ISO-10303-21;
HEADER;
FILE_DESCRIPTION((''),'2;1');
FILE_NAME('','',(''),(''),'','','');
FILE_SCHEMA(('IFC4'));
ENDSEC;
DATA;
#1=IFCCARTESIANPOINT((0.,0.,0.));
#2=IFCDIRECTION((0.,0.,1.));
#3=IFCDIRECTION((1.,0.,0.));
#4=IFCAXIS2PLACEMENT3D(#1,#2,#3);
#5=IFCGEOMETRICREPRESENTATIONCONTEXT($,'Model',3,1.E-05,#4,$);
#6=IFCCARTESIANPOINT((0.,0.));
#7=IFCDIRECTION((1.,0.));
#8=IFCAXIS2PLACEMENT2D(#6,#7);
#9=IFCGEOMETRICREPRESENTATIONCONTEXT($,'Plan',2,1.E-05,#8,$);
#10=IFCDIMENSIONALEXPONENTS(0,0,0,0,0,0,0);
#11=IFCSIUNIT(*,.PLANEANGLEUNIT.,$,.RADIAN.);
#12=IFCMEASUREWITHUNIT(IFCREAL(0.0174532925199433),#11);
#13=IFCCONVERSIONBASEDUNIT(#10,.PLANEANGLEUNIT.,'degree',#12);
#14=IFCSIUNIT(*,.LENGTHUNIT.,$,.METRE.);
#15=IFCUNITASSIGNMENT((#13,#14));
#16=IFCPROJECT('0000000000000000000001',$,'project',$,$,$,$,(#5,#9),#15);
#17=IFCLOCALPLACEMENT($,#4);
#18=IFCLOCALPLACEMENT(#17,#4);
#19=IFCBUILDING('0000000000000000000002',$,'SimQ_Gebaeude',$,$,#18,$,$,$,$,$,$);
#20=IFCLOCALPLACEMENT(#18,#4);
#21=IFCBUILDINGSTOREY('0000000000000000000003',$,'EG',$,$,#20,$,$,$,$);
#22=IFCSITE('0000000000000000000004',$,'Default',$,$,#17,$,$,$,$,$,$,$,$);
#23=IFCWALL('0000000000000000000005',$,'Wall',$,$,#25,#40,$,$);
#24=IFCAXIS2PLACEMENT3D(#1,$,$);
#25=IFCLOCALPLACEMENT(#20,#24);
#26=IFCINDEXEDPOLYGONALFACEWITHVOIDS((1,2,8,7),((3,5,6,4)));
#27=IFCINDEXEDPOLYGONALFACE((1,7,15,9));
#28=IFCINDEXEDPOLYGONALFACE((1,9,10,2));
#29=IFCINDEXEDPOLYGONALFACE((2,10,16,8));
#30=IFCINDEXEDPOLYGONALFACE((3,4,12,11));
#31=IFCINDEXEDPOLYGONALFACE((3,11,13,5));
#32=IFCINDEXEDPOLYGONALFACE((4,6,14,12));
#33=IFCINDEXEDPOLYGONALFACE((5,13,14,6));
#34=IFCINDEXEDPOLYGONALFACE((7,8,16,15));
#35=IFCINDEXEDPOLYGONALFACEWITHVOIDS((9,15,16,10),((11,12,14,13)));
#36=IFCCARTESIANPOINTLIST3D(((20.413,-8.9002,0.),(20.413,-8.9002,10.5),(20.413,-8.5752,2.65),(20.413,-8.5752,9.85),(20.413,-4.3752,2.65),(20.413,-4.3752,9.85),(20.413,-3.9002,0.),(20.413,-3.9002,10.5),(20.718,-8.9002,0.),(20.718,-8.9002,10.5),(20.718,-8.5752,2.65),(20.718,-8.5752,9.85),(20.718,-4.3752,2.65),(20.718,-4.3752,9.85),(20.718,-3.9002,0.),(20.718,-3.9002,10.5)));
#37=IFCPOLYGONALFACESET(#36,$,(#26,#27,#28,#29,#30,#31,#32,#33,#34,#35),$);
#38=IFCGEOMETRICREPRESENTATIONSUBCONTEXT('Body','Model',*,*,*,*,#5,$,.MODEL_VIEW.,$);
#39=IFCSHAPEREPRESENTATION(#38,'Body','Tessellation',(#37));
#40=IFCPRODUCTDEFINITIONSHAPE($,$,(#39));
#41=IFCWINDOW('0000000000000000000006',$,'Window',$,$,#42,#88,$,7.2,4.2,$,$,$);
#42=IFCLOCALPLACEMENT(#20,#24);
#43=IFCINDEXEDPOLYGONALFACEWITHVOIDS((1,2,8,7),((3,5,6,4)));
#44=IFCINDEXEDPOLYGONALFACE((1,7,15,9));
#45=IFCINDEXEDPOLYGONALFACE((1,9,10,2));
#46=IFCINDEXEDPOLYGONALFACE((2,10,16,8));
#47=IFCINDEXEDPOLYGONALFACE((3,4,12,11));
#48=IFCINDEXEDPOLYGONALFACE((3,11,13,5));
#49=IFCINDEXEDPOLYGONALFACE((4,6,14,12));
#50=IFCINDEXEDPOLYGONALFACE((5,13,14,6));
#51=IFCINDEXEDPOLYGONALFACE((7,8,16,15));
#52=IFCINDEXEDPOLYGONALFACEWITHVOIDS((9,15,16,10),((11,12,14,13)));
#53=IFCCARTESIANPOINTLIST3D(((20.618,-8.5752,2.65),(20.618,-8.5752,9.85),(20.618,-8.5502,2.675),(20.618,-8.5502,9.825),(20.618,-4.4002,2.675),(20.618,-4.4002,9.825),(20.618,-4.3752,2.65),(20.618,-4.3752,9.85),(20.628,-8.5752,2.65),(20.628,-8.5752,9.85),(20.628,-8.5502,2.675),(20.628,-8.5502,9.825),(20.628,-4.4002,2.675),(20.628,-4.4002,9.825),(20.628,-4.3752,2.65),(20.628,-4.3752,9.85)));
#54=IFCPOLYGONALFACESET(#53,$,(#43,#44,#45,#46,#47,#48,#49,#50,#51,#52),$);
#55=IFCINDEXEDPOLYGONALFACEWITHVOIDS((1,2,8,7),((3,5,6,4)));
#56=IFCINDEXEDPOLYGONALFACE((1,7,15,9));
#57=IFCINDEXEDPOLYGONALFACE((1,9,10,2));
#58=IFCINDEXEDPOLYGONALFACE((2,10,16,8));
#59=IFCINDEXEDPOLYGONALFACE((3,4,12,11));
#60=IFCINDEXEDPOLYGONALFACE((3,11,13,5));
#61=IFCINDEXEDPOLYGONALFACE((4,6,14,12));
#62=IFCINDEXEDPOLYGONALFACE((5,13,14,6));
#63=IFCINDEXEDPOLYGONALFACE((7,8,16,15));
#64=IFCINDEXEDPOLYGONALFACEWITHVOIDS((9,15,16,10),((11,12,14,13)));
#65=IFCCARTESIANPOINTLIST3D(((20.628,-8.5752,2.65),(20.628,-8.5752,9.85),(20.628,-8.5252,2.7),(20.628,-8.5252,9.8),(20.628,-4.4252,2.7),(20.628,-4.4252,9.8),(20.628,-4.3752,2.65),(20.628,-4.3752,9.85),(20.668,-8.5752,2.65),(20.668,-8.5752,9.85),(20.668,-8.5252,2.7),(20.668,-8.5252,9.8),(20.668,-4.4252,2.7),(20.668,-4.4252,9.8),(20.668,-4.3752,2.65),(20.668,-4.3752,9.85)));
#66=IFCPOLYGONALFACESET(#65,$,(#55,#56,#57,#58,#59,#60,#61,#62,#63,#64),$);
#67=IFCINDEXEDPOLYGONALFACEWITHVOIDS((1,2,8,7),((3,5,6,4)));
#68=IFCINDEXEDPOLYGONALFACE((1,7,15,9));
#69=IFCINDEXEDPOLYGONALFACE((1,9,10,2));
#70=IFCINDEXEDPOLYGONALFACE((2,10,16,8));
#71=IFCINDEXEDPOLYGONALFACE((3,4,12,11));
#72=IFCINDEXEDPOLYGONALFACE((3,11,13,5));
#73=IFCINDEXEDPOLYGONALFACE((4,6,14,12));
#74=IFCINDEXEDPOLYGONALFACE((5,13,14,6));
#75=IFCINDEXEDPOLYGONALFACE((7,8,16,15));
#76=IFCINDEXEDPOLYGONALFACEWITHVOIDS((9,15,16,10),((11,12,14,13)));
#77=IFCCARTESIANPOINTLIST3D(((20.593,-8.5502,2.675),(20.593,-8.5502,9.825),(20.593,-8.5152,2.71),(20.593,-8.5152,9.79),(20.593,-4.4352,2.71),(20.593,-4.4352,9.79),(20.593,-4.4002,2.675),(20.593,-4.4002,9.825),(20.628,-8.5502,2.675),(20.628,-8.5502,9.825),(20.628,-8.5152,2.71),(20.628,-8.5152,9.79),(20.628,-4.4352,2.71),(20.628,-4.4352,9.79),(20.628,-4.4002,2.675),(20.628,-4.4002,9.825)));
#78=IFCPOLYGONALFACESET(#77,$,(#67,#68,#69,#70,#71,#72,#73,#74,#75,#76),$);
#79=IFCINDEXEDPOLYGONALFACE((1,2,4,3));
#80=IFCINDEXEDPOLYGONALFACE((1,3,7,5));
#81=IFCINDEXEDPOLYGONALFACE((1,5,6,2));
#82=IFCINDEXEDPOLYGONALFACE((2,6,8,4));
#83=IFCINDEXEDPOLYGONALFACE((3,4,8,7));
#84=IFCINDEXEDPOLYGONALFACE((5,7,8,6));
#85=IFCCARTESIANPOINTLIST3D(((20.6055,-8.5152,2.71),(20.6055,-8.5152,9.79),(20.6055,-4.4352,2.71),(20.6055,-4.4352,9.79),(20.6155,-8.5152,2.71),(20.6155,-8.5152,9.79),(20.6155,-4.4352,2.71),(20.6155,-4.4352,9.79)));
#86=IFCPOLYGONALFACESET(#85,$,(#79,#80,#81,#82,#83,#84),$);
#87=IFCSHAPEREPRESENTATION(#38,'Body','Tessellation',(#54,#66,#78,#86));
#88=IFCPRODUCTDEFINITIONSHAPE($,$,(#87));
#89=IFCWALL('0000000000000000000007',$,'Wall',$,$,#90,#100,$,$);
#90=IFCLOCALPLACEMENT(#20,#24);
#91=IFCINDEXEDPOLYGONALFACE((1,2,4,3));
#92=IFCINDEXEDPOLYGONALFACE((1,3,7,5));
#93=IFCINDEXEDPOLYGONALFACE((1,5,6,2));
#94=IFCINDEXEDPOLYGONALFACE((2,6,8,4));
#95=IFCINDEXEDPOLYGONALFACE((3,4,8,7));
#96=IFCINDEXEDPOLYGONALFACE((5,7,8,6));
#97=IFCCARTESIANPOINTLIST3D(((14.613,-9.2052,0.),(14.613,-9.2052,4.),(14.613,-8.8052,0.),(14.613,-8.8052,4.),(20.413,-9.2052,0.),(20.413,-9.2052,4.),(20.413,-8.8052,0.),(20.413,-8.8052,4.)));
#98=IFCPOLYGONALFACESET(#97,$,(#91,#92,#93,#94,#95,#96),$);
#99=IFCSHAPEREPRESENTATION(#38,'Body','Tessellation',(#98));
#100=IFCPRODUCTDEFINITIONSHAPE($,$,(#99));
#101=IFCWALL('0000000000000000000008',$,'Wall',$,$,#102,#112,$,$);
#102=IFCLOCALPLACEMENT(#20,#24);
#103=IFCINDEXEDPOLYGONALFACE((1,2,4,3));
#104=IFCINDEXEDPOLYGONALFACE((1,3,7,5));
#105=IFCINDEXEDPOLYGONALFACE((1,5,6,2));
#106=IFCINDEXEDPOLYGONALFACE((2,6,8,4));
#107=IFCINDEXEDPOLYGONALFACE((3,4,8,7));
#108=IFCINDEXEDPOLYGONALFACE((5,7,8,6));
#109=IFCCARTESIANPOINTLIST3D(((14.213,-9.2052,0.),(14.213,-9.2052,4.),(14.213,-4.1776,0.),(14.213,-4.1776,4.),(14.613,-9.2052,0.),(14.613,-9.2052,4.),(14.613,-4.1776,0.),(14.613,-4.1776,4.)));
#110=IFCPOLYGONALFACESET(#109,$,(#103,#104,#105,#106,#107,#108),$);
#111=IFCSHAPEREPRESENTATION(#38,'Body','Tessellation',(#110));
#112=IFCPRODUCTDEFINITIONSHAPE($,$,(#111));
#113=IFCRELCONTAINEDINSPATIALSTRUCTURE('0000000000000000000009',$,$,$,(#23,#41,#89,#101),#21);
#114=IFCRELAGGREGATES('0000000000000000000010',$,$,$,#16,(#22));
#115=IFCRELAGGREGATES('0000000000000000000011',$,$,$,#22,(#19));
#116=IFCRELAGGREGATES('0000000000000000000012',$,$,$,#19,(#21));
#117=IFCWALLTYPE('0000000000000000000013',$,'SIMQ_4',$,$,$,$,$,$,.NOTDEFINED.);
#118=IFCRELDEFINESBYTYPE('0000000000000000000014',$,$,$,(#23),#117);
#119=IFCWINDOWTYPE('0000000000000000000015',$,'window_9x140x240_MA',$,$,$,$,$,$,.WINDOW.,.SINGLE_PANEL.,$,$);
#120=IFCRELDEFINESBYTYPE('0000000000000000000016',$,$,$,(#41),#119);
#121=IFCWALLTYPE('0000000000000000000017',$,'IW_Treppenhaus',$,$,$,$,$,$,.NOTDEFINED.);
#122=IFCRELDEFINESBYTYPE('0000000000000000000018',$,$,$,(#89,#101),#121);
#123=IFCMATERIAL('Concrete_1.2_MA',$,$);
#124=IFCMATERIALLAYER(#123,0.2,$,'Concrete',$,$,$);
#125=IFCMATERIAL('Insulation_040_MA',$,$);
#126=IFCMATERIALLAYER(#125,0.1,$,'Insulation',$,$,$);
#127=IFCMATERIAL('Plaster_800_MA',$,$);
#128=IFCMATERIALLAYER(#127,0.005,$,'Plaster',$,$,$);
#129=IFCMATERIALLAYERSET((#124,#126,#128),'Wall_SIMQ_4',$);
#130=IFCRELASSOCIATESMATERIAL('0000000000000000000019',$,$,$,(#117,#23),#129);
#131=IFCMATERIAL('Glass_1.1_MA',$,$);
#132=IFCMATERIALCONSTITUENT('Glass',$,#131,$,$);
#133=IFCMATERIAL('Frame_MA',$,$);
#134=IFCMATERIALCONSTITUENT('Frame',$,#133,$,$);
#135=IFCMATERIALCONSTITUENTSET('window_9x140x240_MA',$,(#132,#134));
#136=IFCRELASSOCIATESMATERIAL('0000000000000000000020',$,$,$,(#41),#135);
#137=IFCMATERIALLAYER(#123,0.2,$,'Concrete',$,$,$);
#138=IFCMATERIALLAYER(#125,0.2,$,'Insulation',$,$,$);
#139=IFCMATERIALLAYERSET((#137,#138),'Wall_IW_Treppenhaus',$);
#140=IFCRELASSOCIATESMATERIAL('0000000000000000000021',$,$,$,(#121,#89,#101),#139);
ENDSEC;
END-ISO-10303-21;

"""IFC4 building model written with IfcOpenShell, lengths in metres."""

from ifc_helpers import new_model, entity, si_unit, converted_unit, frame, origin_with_axes, origin_2d_with_axis, place, context, subcontext, project, spatial, line, indexed_curve, outline, extrude, shape, source, transform, mapped, material, layer, layer_set, layer_usage, constituent, constituent_set, type_object, type_shapes, element, fill, save


model = new_model("IFC4")

# Units and contexts
model_context = context("Model", 3, precision=1e-05, world=origin_with_axes())
plan_context = context("Plan", 2, precision=1e-05, world=origin_2d_with_axis())
body_context_1 = subcontext(model_context, "Body", "Model", "MODEL_VIEW")
body_context_2 = subcontext(plan_context, "Body", "Plan", "PLAN_VIEW")
ifc_project = project(units=[converted_unit("PLANEANGLEUNIT", "degree", entity("IfcReal", 0.0174532925199433), si_unit("PLANEANGLEUNIT", "RADIAN"), dimensions=[0, 0, 0, 0, 0, 0, 0]), si_unit("LENGTHUNIT", "METRE")], contexts=[model_context, plan_context])

# Site, building, storey
site_placement = place(None, origin_with_axes())
site = spatial("IfcSite", under=ifc_project, at=site_placement, Name="Default")
building_placement = place(site_placement, origin_with_axes())
building = spatial("IfcBuilding", under=site, at=building_placement, Name="SimQ_Gebaeude")
storey_placement = place(building_placement, origin_with_axes())
storey = spatial("IfcBuildingStorey", under=building, at=storey_placement, Name="EG")

# Shared definitions
ifc_material_1 = material(Name="Insulation_040_MA")
ifc_material_2 = material(Name="Concrete_1.2_MA")

# Shared definitions
ifc_layer_1 = layer(ifc_material_2, 0.2, Name="Concrete")
ifc_layer_2 = layer(ifc_material_1, 0.1, Name="Insulation")
ifc_material_3 = material(Name="Plaster_800_MA")
ifc_layer_3 = layer(ifc_material_3, 0.005, Name="Plaster")
ifc_layer_set_1 = layer_set([ifc_layer_1, ifc_layer_2, ifc_layer_3], Name="Wall_SIMQ_4")
wall_type_1 = type_object("IfcWallType", Name="SIMQ_4", PredefinedType="NOTDEFINED", material=ifc_layer_set_1)

# Wall, opening, window
ifc_layer_usage_1 = layer_usage(ifc_layer_set_1, "AXIS2", "POSITIVE", 0.0)
wall_1_placement = place(storey_placement, frame((20.718, -8.9002, 0.0), z_axis=(0.0, 0.0, 1.0), x_axis=(0.0, 1.0, 0.0)))
wall_1 = element("IfcWall", 1, at=wall_1_placement, inside=storey, type_object=wall_type_1, material=ifc_layer_usage_1, Name="Wall", context=body_context_1, shape_type="SweptSolid", body=[
    extrude(outline(indexed_curve([(0.0, 0.0), (0.0, 0.305), (5.0, 0.305), (5.0, 0.0), (0.0, 0.0)], self_intersect=False)), origin_with_axes(), (0.0, 0.0, 1.0), 10.5),
])
shared_shape_1 = source(origin_with_axes(), body_context_1, "Body", "SweptSolid", [
    extrude(outline(indexed_curve([(0.0, 0.0), (4.2, 0.0), (4.2, 7.2), (0.0, 7.2)], segments=[line(1, 2, 3, 4, 1)])), frame((0.0, -0.6, 0.0), z_axis=(0.0, -1.0, 0.0), x_axis=(1.0, 0.0, 0.0)), (0.0, 0.0, -1.0), 1.2),
])
opening_1_placement = place(wall_1_placement, frame((0.325, 0.0, 2.65), z_axis=(0.0, 0.0, 1.0), x_axis=(1.0, 0.0, 0.0)))
opening_1 = element("IfcOpeningElement", 2, at=opening_1_placement, cuts=wall_1, PredefinedType="OPENING", context=body_context_1, shape_type="MappedRepresentation", body=[
    mapped(shared_shape_1, transform((0.0, 0.0, 0.0), x_axis=(1.0, 0.0, 0.0), y_axis=(0.0, 1.0, 0.0), z_axis=(0.0, 0.0, 1.0), scale=1.0)),
])
ifc_material_4 = material(Name="Glass_1.1_MA")
ifc_constituent_1 = constituent(ifc_material_4, Name="Glass")
ifc_material_5 = material(Name="Frame_MA")
ifc_constituent_2 = constituent(ifc_material_5, Name="Frame")
ifc_constituent_set = constituent_set(constituents=[ifc_constituent_1, ifc_constituent_2], Name="window_9x140x240_MA")
window_type = type_object("IfcWindowType", Name="window_9x140x240_MA", PartitioningType="SINGLE_PANEL", PredefinedType="WINDOW")
shared_shape_2 = source(origin_with_axes(), body_context_1, "Body", "SweptSolid", [
    extrude(outline(indexed_curve([(0.0, 0.0), (4.2, 0.0), (4.2, 7.2), (0.0, 7.2)], segments=[line(1, 2, 3, 4, 1)]), holes=[indexed_curve([(0.025, 0.025), (4.175, 0.025), (4.175, 7.175), (0.025, 7.175)], segments=[line(1, 2, 3, 4, 1)])]), frame((0.0, 0.09, 0.0), z_axis=(0.0, -1.0, 0.0), x_axis=(1.0, 0.0, 0.0)), (0.0, 0.0, -1.0), 0.01),
    extrude(outline(indexed_curve([(0.0, 0.0), (4.2, 0.0), (4.2, 7.2), (0.0, 7.2)], segments=[line(1, 2, 3, 4, 1)]), holes=[indexed_curve([(0.05, 0.05), (4.15, 0.05), (4.15, 7.15), (0.05, 7.15)], segments=[line(1, 2, 3, 4, 1)])]), frame((0.0, 0.05, 0.0), z_axis=(0.0, -1.0, 0.0), x_axis=(1.0, 0.0, 0.0)), (0.0, 0.0, -1.0), 0.04),
    extrude(outline(indexed_curve([(0.0, 0.0), (4.15, 0.0), (4.15, 7.15), (0.0, 7.15)], segments=[line(1, 2, 3, 4, 1)]), holes=[indexed_curve([(0.035, 0.035), (4.115, 0.035), (4.115, 7.115), (0.035, 7.115)], segments=[line(1, 2, 3, 4, 1)])]), frame((0.025, 0.09, 0.025), z_axis=(0.0, -1.0, 0.0), x_axis=(1.0, 0.0, 0.0)), (0.0, 0.0, -1.0), 0.035),
    extrude(outline(indexed_curve([(0.035, 0.035), (4.115, 0.035), (4.115, 7.115), (0.035, 7.115)], segments=[line(1, 2, 3, 4, 1)])), frame((0.025, 0.1025, 0.025), z_axis=(0.0, -1.0, 0.0), x_axis=(1.0, 0.0, 0.0)), (0.0, 0.0, -1.0), 0.01),
])
shared_shape_3 = source(origin_with_axes(), body_context_2, "Body", "Curve2D", [
    entity("IfcIndexedPolyCurve", entity("IfcCartesianPointList2D", [[0.05, 0.05], [4.15, 0.05]])),
    entity("IfcIndexedPolyCurve", entity("IfcCartesianPointList2D", [[0.0, 0.1], [0.025, 0.1], [0.025, 0.09], [0.05, 0.09], [0.05, 0.05], [0.0, 0.05]]), [entity("IfcLineIndex", [1, 2, 3, 4, 5, 6, 1])]),
    entity("IfcIndexedPolyCurve", entity("IfcCartesianPointList2D", [[4.2, 0.1], [4.175, 0.1], [4.175, 0.09], [4.15, 0.09], [4.15, 0.05], [4.2, 0.05]]), [entity("IfcLineIndex", [1, 2, 3, 4, 5, 6, 1])]),
    entity("IfcIndexedPolyCurve", entity("IfcCartesianPointList2D", [[0.025, 0.09], [0.06, 0.09], [0.06, 0.125], [0.025, 0.125]]), [entity("IfcLineIndex", [1, 2, 3, 4, 1])]),
    entity("IfcIndexedPolyCurve", entity("IfcCartesianPointList2D", [[4.175, 0.09], [4.14, 0.09], [4.14, 0.125], [4.175, 0.125]]), [entity("IfcLineIndex", [1, 2, 3, 4, 1])]),
    entity("IfcIndexedPolyCurve", entity("IfcCartesianPointList2D", [[0.06, 0.09], [4.14, 0.09]])),
    entity("IfcIndexedPolyCurve", entity("IfcCartesianPointList2D", [[0.06, 0.125], [4.14, 0.125]])),
    entity("IfcIndexedPolyCurve", entity("IfcCartesianPointList2D", [[0.06, 0.1075], [4.14, 0.1075]])),
])
type_shapes(window_type, [shared_shape_2, shared_shape_3])
window_placement = place(opening_1_placement, frame((0.0, 0.0, 0.0), z_axis=(0.0, 0.0, 1.0), x_axis=(1.0, 0.0, 0.0)))
window = element("IfcWindow", 3, at=window_placement, inside=storey, type_object=window_type, material=ifc_constituent_set, Name="Window", OverallHeight=7.2, OverallWidth=4.2, shapes=[
    shape(body_context_1, "Body", "MappedRepresentation", [mapped(shared_shape_2, transform((0.0, 0.0, 0.0), x_axis=(1.0, 0.0, 0.0), y_axis=(0.0, 1.0, 0.0), z_axis=(0.0, 0.0, 1.0), scale=1.0))]),
    shape(body_context_2, "Body", "MappedRepresentation", [mapped(shared_shape_3, transform((0.0, 0.0, 0.0), x_axis=(1.0, 0.0, 0.0), y_axis=(0.0, 1.0, 0.0), z_axis=(0.0, 0.0, 1.0), scale=1.0))]),
])
fill(opening_1, window)

# Walls
ifc_layer_4 = layer(ifc_material_2, 0.2, Name="Concrete")
ifc_layer_5 = layer(ifc_material_1, 0.2, Name="Insulation")
ifc_layer_set_2 = layer_set([ifc_layer_4, ifc_layer_5], Name="Wall_IW_Treppenhaus")
ifc_layer_usage_2 = layer_usage(ifc_layer_set_2, "AXIS2", "POSITIVE", 0.0)
wall_type_2 = type_object("IfcWallType", Name="IW_Treppenhaus", PredefinedType="NOTDEFINED", material=ifc_layer_set_2)
wall_2_placement = place(storey_placement, frame((20.413, -8.8052, 0.0), z_axis=(0.0, 0.0, 1.0), x_axis=(-1.0, 0.000001, 0.0)))
element("IfcWall", 4, at=wall_2_placement, inside=storey, type_object=wall_type_2, material=ifc_layer_usage_2, Name="Wall", context=body_context_1, shape_type="SweptSolid", body=[
    extrude(outline(indexed_curve([(0.0, 0.0), (0.0, 0.4), (5.8, 0.4), (5.8, 0.0), (0.0, 0.0)], self_intersect=False)), origin_with_axes(), (0.0, 0.0, 1.0), 4.0),
])
ifc_layer_usage_3 = layer_usage(ifc_layer_set_2, "AXIS2", "POSITIVE", 0.0)
wall_3_placement = place(storey_placement, frame((14.213, -4.1776, 0.0), z_axis=(0.0, 0.0, 1.0), x_axis=(-0.000001, -1.0, 0.0)))
element("IfcWall", 5, at=wall_3_placement, inside=storey, type_object=wall_type_2, material=ifc_layer_usage_3, Name="Wall", context=body_context_1, shape_type="SweptSolid", body=[
    extrude(outline(indexed_curve([(0.0, 0.0), (0.0, 0.4), (5.0276, 0.4), (5.0276, 0.0), (0.0, 0.0)], self_intersect=False)), origin_with_axes(), (0.0, 0.0, 1.0), 4.0),
])

save(model, "model.ifc")
